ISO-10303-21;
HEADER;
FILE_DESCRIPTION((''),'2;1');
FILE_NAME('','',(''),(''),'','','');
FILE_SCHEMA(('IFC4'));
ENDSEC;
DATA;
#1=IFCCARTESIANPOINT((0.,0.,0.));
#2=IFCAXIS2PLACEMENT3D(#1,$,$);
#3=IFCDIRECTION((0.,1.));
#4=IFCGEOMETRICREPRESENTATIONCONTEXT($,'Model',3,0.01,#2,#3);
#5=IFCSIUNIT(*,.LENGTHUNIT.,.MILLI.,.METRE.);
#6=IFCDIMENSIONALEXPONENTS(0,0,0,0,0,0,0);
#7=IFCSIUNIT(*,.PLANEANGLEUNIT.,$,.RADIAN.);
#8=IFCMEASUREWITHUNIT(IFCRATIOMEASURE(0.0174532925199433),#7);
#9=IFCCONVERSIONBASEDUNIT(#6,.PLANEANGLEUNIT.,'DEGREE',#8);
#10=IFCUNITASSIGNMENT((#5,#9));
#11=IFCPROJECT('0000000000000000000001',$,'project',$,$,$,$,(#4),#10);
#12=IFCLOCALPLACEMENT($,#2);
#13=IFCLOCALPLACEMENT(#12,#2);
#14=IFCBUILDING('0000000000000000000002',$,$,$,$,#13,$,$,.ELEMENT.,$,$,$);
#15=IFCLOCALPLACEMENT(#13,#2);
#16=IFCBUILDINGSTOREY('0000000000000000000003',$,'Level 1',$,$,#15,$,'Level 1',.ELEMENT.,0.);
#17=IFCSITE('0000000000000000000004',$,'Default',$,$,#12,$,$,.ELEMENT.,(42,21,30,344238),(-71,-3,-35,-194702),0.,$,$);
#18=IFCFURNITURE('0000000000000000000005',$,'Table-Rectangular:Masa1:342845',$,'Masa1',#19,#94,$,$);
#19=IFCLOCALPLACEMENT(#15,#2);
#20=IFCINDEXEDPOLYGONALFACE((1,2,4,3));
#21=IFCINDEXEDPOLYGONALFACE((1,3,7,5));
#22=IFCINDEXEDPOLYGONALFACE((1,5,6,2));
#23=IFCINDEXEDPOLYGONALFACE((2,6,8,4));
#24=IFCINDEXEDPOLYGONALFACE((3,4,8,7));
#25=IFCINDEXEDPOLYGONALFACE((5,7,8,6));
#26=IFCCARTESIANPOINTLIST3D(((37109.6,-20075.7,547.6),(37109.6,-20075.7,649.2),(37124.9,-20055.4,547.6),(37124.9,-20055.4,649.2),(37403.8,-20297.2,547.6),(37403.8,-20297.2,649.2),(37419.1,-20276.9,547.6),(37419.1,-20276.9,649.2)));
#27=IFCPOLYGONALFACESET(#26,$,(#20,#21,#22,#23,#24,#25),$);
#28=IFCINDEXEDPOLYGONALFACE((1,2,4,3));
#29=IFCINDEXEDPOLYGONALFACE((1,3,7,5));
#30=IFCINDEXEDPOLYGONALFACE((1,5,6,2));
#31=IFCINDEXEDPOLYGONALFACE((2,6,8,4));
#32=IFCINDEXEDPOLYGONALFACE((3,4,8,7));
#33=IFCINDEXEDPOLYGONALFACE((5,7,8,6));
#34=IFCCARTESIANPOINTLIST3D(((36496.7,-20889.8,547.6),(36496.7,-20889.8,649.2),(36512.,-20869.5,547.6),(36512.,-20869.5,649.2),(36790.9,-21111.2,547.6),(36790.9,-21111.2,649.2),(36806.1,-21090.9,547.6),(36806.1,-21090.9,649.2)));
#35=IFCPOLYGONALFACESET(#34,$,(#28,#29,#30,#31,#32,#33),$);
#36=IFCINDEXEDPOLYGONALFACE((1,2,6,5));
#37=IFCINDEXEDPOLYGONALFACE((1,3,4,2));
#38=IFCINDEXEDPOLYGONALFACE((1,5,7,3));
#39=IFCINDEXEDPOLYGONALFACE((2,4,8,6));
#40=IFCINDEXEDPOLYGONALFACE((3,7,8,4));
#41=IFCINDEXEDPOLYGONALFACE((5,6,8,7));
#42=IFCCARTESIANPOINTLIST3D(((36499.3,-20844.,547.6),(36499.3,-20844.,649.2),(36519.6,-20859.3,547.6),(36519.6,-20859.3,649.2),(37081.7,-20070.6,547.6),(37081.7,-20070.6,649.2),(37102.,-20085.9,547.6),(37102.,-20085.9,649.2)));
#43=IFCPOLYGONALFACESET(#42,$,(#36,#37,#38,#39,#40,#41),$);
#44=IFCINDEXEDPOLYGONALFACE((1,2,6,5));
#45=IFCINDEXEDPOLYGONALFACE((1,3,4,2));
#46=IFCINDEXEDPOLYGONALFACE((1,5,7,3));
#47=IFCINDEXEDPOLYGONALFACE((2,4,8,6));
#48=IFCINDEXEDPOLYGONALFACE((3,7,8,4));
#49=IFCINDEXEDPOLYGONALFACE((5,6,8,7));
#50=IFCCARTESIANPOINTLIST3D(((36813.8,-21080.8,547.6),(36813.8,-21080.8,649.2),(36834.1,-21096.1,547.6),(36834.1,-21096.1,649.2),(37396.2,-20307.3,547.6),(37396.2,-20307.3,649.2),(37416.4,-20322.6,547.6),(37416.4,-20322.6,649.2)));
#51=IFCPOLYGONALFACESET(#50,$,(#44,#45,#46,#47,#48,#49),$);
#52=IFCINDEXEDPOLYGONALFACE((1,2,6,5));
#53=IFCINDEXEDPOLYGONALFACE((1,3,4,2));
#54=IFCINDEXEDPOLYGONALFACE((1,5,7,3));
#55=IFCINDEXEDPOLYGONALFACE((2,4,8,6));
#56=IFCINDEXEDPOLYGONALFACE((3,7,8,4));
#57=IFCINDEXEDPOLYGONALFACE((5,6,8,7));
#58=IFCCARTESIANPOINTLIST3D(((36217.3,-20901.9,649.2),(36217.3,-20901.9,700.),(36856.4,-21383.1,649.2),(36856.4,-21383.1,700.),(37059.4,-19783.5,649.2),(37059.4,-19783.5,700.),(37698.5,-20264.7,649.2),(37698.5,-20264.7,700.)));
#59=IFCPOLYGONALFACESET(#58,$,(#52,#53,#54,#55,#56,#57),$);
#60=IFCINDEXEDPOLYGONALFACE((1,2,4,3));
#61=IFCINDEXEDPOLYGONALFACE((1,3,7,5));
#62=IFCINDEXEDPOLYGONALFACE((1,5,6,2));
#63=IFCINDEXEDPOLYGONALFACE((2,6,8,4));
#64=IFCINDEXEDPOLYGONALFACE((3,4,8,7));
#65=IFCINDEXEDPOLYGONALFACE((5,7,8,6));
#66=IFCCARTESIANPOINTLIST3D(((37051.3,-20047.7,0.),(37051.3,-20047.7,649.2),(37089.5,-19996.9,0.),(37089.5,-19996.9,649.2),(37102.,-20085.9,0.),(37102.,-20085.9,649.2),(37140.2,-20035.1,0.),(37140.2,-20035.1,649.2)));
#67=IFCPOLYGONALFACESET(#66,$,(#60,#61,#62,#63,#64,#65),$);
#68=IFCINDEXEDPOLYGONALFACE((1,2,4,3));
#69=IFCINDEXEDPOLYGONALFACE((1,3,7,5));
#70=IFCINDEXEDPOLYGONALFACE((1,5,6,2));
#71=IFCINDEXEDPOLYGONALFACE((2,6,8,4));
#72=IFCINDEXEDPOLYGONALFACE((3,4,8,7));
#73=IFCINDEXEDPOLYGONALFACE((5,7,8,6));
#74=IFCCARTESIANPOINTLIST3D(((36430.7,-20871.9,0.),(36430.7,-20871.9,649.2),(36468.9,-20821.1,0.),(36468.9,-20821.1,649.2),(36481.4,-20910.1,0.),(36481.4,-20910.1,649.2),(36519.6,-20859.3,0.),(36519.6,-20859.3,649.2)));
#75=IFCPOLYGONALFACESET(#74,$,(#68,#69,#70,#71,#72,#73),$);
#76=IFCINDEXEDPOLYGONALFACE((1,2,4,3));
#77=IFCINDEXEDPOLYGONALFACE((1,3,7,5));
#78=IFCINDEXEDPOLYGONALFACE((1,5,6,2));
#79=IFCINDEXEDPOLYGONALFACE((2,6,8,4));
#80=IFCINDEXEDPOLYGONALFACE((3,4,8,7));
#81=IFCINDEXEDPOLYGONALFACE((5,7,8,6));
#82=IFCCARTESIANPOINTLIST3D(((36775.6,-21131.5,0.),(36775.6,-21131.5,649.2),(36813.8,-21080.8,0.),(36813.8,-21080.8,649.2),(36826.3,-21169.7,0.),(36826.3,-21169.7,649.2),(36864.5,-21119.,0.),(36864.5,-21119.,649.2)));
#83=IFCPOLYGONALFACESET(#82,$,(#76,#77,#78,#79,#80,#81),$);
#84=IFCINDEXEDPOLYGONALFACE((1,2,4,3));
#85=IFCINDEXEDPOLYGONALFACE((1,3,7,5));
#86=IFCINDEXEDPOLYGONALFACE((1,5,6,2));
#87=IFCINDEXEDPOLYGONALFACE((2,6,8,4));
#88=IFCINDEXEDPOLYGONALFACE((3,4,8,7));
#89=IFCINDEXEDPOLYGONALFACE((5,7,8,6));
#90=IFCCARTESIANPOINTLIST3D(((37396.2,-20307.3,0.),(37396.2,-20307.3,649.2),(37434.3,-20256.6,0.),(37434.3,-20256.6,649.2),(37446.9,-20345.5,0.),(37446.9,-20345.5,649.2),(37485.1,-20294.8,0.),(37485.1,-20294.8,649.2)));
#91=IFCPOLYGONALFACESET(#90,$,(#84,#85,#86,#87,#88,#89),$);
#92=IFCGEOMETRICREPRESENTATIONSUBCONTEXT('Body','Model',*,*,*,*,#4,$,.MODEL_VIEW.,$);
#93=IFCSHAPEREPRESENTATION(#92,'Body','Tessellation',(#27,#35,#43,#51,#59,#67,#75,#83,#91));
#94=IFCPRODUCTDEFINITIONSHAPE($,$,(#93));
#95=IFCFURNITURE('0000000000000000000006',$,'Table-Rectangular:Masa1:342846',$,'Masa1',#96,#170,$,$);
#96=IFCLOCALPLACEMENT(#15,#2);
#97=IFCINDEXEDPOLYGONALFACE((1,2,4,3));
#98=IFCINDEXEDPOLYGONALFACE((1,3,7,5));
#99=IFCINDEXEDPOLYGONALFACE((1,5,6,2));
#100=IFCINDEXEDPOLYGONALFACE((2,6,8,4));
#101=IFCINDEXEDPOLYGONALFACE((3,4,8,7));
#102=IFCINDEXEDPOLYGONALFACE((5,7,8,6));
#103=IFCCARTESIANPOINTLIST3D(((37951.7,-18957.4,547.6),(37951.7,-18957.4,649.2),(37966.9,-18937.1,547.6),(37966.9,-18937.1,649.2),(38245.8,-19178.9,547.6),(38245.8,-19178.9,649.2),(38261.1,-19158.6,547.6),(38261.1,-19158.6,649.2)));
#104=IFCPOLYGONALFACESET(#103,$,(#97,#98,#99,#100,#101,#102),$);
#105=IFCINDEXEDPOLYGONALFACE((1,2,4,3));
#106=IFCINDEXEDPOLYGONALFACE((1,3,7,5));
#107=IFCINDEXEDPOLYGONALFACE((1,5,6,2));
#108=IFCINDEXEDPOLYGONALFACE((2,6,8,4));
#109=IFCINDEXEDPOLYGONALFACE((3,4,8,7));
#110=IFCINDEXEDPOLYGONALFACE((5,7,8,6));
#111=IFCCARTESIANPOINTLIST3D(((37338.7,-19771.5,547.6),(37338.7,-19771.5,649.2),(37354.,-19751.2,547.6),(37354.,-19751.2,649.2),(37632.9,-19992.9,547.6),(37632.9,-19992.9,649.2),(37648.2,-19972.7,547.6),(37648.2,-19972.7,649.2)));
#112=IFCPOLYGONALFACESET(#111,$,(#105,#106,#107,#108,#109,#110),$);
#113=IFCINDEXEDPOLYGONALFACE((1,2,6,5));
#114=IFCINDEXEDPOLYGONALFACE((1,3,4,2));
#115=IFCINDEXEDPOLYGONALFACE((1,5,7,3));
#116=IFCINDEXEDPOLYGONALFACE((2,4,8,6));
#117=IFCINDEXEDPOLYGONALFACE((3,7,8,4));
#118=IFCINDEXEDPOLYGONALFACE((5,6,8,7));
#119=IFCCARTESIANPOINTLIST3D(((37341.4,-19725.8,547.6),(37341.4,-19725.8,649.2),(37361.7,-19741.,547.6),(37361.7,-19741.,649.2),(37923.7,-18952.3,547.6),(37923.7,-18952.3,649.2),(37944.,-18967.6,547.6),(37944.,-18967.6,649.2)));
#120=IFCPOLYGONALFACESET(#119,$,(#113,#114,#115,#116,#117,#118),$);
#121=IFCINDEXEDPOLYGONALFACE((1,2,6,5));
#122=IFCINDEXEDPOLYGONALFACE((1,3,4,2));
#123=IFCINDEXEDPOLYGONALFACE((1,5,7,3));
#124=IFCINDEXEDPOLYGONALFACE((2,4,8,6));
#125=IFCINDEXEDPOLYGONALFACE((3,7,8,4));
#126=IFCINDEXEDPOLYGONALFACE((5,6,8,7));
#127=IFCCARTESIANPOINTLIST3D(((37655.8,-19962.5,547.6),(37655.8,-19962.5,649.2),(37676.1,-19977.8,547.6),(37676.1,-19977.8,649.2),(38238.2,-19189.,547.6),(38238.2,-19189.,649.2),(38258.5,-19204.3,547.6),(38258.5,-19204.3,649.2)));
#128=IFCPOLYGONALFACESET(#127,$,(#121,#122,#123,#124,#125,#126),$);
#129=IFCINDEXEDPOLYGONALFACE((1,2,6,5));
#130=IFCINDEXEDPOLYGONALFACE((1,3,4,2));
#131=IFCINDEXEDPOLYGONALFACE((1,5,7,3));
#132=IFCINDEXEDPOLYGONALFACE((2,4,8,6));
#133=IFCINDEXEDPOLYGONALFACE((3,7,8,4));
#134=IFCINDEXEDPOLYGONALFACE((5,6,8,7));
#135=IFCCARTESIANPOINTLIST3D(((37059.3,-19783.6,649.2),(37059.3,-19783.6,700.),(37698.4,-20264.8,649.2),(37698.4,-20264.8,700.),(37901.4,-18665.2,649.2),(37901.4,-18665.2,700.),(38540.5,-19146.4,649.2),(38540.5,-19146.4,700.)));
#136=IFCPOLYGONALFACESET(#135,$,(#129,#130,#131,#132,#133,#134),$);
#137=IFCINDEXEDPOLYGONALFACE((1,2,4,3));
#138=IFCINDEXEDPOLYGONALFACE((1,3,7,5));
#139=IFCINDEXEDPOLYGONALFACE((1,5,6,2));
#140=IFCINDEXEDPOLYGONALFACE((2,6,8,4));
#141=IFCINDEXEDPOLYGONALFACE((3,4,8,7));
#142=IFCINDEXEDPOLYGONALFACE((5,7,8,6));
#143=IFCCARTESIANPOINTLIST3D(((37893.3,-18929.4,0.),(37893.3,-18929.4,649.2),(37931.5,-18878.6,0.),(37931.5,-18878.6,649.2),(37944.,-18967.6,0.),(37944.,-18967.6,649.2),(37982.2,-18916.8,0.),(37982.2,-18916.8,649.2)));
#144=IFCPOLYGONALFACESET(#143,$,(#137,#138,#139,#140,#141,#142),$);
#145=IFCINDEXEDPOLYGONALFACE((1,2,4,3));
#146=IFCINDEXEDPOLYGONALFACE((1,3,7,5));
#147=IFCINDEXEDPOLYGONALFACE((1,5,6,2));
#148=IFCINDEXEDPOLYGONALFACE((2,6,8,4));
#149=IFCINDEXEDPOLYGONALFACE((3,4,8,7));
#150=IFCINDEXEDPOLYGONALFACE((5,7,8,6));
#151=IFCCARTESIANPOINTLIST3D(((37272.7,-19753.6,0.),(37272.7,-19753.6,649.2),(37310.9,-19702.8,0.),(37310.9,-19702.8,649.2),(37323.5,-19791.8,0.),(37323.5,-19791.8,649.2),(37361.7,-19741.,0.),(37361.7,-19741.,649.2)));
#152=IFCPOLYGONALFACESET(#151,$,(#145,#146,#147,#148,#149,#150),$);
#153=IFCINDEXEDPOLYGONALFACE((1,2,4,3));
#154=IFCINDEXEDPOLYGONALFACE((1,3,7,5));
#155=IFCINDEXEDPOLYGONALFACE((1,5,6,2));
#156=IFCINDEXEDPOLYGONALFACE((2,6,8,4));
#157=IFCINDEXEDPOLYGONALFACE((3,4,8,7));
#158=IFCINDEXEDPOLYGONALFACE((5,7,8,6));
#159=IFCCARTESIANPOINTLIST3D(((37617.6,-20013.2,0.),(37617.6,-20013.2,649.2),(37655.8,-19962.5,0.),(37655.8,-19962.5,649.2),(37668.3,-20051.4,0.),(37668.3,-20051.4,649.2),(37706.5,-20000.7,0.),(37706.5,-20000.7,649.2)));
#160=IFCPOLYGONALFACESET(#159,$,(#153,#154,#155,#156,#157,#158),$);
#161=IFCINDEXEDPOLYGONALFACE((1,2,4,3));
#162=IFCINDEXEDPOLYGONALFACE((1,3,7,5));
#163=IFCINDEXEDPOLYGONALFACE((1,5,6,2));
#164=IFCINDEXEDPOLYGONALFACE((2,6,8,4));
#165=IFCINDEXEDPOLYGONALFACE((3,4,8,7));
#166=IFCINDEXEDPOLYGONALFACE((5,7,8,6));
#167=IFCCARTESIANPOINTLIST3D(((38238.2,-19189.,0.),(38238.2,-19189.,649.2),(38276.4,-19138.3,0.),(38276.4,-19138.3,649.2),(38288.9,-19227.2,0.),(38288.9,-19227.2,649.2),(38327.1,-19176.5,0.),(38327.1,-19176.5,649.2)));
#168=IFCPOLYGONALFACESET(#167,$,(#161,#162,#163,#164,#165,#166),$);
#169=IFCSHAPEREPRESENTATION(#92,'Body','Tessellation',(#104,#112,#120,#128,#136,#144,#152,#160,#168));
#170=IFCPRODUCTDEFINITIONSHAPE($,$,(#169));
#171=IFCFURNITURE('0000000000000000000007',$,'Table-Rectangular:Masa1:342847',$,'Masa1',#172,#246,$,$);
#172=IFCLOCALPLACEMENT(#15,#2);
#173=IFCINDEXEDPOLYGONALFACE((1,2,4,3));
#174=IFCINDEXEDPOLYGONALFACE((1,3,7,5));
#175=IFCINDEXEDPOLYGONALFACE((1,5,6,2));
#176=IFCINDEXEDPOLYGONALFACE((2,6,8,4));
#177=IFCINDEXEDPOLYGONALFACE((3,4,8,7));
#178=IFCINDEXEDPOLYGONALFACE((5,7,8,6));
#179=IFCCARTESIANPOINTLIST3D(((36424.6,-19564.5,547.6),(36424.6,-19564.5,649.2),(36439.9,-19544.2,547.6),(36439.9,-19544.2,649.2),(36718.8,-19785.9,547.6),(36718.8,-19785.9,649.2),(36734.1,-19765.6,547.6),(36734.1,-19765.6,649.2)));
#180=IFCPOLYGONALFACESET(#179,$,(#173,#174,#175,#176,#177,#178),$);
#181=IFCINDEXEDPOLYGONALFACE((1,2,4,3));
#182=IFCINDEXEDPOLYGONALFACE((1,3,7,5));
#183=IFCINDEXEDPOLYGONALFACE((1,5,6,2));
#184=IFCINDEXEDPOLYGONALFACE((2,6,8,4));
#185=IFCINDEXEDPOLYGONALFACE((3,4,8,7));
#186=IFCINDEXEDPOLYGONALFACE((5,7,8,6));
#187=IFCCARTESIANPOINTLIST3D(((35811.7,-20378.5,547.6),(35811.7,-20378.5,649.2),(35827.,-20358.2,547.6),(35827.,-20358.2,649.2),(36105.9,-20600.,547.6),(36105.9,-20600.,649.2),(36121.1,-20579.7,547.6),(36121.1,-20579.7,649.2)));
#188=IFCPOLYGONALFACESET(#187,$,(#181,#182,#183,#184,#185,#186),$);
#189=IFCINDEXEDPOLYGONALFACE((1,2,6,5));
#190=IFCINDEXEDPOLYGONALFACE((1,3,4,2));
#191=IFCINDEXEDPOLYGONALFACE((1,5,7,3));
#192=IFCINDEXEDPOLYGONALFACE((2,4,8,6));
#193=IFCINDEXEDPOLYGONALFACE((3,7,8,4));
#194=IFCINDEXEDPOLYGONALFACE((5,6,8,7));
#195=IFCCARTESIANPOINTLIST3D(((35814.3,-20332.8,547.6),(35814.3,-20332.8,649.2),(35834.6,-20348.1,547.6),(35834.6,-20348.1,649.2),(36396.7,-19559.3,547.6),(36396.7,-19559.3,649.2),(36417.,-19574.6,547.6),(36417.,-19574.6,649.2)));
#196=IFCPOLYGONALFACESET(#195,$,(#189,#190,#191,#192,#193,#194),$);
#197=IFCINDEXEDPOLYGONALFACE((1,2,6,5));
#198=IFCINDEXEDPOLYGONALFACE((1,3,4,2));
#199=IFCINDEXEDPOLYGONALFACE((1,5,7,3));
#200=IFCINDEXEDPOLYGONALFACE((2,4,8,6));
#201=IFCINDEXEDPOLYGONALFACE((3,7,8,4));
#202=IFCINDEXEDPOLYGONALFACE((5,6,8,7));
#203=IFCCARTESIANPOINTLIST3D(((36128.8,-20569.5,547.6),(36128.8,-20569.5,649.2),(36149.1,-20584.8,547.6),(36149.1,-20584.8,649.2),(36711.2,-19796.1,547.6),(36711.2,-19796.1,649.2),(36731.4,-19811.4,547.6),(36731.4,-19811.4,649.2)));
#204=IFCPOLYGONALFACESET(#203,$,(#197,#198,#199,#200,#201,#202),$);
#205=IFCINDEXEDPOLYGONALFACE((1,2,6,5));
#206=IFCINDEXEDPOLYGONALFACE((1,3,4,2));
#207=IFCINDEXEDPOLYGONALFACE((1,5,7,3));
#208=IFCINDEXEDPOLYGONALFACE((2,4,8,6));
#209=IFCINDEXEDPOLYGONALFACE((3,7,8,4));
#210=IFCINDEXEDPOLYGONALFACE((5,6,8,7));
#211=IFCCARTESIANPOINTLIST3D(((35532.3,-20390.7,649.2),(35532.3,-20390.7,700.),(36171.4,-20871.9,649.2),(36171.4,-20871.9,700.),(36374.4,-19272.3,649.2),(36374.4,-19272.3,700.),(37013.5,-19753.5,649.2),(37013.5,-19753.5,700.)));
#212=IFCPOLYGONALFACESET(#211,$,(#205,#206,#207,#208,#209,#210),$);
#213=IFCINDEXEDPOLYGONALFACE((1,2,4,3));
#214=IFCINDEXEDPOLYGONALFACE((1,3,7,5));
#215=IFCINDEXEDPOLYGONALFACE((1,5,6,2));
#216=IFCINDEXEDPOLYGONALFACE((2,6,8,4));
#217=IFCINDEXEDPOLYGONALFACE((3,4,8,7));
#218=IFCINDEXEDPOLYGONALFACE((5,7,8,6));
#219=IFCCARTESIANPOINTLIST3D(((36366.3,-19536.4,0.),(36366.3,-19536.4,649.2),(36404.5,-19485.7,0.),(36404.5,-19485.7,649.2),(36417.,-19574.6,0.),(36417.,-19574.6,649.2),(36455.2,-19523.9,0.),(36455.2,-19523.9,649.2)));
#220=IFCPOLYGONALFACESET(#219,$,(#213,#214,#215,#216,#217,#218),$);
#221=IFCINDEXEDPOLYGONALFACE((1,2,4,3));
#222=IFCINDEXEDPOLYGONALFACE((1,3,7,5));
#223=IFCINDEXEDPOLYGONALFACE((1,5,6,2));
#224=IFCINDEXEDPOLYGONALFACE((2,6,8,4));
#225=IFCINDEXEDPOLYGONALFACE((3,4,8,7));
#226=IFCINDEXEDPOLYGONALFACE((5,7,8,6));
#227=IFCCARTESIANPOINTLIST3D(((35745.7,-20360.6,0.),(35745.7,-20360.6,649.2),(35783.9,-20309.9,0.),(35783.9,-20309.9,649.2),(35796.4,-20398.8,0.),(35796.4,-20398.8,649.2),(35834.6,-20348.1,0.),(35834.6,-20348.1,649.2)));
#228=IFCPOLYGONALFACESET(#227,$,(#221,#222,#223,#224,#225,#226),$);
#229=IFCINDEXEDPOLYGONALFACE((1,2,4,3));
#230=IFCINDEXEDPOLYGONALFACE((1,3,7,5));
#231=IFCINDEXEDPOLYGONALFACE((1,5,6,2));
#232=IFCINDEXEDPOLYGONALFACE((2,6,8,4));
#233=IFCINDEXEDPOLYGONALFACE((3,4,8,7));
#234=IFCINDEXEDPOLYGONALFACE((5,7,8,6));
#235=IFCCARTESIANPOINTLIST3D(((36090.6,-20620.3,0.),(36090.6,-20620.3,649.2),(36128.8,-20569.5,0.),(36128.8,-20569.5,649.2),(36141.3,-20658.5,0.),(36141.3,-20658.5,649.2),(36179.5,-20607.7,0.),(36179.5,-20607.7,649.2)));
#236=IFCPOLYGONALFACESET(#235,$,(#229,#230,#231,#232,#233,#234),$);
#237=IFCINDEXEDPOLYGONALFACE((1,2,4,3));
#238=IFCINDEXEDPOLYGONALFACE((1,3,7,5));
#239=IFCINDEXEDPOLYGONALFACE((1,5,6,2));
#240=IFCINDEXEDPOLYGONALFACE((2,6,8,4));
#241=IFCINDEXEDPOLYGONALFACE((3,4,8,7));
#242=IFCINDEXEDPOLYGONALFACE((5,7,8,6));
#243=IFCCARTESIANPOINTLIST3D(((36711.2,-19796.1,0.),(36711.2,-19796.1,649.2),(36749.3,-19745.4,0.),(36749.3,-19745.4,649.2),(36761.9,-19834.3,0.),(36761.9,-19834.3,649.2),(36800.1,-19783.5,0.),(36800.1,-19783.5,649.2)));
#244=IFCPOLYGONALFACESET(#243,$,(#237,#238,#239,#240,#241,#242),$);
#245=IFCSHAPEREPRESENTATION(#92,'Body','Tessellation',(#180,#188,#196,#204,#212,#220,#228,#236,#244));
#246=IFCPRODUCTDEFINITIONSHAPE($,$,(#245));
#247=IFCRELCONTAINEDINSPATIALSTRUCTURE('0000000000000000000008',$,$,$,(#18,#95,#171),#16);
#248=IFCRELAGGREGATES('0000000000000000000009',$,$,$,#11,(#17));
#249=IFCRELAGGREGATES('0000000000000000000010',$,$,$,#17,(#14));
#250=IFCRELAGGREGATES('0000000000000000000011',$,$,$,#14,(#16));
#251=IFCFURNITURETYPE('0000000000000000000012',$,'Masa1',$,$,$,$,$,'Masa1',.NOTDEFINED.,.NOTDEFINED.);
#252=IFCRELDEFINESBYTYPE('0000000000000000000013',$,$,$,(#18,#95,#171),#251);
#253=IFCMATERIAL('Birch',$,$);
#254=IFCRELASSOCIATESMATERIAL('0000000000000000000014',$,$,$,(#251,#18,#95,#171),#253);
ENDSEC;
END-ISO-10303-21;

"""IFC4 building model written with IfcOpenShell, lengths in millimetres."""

from ifc_helpers import new_model, entity, si_unit, converted_unit, direction, frame, frame_2d, origin, origin_2d_with_axis, place, context, subcontext, project, spatial, rectangle, extrude, source, transform, mapped, material, type_object, type_shapes, element, save


model = new_model("IFC4")

# Units and contexts
model_context = context("Model", 3, precision=0.01, world=origin(), true_north=direction((0.0, 1.0)))
body_context = subcontext(model_context, "Body", "Model", "MODEL_VIEW")
ifc_project = project(units=[si_unit("LENGTHUNIT", "METRE", prefix="MILLI"), converted_unit("PLANEANGLEUNIT", "DEGREE", entity("IfcRatioMeasure", 0.0174532925199433), si_unit("PLANEANGLEUNIT", "RADIAN"), dimensions=[0, 0, 0, 0, 0, 0, 0])], contexts=[model_context])

# Site, building, storey
site_placement = place(None, origin())
site = spatial("IfcSite", under=ifc_project, at=site_placement, Name="Default", CompositionType="ELEMENT", RefLatitude=(42, 21, 30, 344238), RefLongitude=(-71, -3, -35, -194702), RefElevation=0.0)
building_placement = place(site_placement, origin())
building = spatial("IfcBuilding", under=site, at=building_placement, CompositionType="ELEMENT")
storey_placement = place(building_placement, origin())
storey = spatial("IfcBuildingStorey", under=building, at=storey_placement, Name="Level 1", LongName="Level 1", CompositionType="ELEMENT", Elevation=0.0)

# Furniture
ifc_material_1 = material(Name="Birch")
furniture_type_1 = type_object("IfcFurnitureType", Name="Masa1", ElementType="Masa1", AssemblyPlace="NOTDEFINED", PredefinedType="NOTDEFINED", material=ifc_material_1)
shared_shape_1 = source(origin(), body_context, "Body", "SweptSolid", [
    extrude(rectangle(XDim=25.4, YDim=368.2, at=origin_2d_with_axis()), frame((509.5, 0.0, 547.6)), (0.0, 0.0, 1.0), 101.6),
    extrude(rectangle(XDim=368.2, YDim=25.4, at=origin_2d_with_axis()), frame((-509.5, 0.0, 547.6), z_axis=(0.0, 0.0, 1.0), x_axis=(0.0, 1.0, 0.0)), (0.0, 0.0, 1.0), 101.6),
    extrude(rectangle(XDim=968.2, YDim=25.4, at=frame_2d((0.0, 0.0), x_axis=(1.0, 0.0))), frame((0.0, 196.8, 547.6), z_axis=(0.0, 0.0, 1.0), x_axis=(-1.0, 0.0, 0.0)), (0.0, 0.0, 1.0), 101.6),
    extrude(rectangle(XDim=25.4, YDim=968.2, at=origin_2d_with_axis()), frame((0.0, -196.8, 547.6), z_axis=(0.0, 0.0, 1.0), x_axis=(0.0, 1.0, 0.0)), (0.0, 0.0, 1.0), 101.6),
    extrude(rectangle(XDim=1400.0, YDim=800.0, at=origin_2d_with_axis()), frame((0.0, 0.0, 649.2), z_axis=(0.0, 0.0, 1.0), x_axis=(-1.0, 0.0, 0.0)), (0.0, 0.0, 1.0), 50.8),
    extrude(rectangle(XDim=63.5, YDim=63.5, at=origin_2d_with_axis()), frame((515.9, 215.9, 0.0), z_axis=(0.0, 0.0, 1.0), x_axis=(0.0, -1.0, 0.0)), (0.0, 0.0, 1.0), 649.2),
    extrude(rectangle(XDim=63.5, YDim=63.5, at=origin_2d_with_axis()), frame((-515.9, 215.9, 0.0), z_axis=(0.0, 0.0, 1.0), x_axis=(-1.0, 0.0, 0.0)), (0.0, 0.0, 1.0), 649.2),
    extrude(rectangle(XDim=63.5, YDim=63.5, at=origin_2d_with_axis()), frame((-515.9, -215.9, 0.0), z_axis=(0.0, 0.0, 1.0), x_axis=(0.0, 1.0, 0.0)), (0.0, 0.0, 1.0), 649.2),
    extrude(rectangle(XDim=63.5, YDim=63.5, at=frame_2d((0.0, 0.0), x_axis=(1.0, 0.0))), frame((515.9, -215.9, 0.0)), (0.0, 0.0, 1.0), 649.2),
])
type_shapes(furniture_type_1, [shared_shape_1])
for number, where, z_axis, x_axis, name in (
    (1, (36957.9, -20583.3, 0.0), (0.0, 0.0, 1.0), (0.601507, 0.798867, 0.0), "Table-Rectangular:Masa1:342845"),
    (2, (37799.9, -19465.0, 0.0), (0.0, 0.0, 1.0), (0.601507, 0.798867, 0.0), "Table-Rectangular:Masa1:342846"),
    (3, (36272.9, -20072.1, 0.0), (0.0, 0.0, 1.0), (0.601507, 0.798867, 0.0), "Table-Rectangular:Masa1:342847"),
):
    element("IfcFurniture", number, at=place(storey_placement, frame(where, z_axis=z_axis, x_axis=x_axis)), inside=storey, type_object=furniture_type_1, material=ifc_material_1, Name=name, ObjectType="Masa1", context=body_context, shape_type="MappedRepresentation", body=[
        mapped(shared_shape_1, transform((0.0, 0.0, 0.0), scale=1.0)),
    ])

save(model, "model.ifc")
